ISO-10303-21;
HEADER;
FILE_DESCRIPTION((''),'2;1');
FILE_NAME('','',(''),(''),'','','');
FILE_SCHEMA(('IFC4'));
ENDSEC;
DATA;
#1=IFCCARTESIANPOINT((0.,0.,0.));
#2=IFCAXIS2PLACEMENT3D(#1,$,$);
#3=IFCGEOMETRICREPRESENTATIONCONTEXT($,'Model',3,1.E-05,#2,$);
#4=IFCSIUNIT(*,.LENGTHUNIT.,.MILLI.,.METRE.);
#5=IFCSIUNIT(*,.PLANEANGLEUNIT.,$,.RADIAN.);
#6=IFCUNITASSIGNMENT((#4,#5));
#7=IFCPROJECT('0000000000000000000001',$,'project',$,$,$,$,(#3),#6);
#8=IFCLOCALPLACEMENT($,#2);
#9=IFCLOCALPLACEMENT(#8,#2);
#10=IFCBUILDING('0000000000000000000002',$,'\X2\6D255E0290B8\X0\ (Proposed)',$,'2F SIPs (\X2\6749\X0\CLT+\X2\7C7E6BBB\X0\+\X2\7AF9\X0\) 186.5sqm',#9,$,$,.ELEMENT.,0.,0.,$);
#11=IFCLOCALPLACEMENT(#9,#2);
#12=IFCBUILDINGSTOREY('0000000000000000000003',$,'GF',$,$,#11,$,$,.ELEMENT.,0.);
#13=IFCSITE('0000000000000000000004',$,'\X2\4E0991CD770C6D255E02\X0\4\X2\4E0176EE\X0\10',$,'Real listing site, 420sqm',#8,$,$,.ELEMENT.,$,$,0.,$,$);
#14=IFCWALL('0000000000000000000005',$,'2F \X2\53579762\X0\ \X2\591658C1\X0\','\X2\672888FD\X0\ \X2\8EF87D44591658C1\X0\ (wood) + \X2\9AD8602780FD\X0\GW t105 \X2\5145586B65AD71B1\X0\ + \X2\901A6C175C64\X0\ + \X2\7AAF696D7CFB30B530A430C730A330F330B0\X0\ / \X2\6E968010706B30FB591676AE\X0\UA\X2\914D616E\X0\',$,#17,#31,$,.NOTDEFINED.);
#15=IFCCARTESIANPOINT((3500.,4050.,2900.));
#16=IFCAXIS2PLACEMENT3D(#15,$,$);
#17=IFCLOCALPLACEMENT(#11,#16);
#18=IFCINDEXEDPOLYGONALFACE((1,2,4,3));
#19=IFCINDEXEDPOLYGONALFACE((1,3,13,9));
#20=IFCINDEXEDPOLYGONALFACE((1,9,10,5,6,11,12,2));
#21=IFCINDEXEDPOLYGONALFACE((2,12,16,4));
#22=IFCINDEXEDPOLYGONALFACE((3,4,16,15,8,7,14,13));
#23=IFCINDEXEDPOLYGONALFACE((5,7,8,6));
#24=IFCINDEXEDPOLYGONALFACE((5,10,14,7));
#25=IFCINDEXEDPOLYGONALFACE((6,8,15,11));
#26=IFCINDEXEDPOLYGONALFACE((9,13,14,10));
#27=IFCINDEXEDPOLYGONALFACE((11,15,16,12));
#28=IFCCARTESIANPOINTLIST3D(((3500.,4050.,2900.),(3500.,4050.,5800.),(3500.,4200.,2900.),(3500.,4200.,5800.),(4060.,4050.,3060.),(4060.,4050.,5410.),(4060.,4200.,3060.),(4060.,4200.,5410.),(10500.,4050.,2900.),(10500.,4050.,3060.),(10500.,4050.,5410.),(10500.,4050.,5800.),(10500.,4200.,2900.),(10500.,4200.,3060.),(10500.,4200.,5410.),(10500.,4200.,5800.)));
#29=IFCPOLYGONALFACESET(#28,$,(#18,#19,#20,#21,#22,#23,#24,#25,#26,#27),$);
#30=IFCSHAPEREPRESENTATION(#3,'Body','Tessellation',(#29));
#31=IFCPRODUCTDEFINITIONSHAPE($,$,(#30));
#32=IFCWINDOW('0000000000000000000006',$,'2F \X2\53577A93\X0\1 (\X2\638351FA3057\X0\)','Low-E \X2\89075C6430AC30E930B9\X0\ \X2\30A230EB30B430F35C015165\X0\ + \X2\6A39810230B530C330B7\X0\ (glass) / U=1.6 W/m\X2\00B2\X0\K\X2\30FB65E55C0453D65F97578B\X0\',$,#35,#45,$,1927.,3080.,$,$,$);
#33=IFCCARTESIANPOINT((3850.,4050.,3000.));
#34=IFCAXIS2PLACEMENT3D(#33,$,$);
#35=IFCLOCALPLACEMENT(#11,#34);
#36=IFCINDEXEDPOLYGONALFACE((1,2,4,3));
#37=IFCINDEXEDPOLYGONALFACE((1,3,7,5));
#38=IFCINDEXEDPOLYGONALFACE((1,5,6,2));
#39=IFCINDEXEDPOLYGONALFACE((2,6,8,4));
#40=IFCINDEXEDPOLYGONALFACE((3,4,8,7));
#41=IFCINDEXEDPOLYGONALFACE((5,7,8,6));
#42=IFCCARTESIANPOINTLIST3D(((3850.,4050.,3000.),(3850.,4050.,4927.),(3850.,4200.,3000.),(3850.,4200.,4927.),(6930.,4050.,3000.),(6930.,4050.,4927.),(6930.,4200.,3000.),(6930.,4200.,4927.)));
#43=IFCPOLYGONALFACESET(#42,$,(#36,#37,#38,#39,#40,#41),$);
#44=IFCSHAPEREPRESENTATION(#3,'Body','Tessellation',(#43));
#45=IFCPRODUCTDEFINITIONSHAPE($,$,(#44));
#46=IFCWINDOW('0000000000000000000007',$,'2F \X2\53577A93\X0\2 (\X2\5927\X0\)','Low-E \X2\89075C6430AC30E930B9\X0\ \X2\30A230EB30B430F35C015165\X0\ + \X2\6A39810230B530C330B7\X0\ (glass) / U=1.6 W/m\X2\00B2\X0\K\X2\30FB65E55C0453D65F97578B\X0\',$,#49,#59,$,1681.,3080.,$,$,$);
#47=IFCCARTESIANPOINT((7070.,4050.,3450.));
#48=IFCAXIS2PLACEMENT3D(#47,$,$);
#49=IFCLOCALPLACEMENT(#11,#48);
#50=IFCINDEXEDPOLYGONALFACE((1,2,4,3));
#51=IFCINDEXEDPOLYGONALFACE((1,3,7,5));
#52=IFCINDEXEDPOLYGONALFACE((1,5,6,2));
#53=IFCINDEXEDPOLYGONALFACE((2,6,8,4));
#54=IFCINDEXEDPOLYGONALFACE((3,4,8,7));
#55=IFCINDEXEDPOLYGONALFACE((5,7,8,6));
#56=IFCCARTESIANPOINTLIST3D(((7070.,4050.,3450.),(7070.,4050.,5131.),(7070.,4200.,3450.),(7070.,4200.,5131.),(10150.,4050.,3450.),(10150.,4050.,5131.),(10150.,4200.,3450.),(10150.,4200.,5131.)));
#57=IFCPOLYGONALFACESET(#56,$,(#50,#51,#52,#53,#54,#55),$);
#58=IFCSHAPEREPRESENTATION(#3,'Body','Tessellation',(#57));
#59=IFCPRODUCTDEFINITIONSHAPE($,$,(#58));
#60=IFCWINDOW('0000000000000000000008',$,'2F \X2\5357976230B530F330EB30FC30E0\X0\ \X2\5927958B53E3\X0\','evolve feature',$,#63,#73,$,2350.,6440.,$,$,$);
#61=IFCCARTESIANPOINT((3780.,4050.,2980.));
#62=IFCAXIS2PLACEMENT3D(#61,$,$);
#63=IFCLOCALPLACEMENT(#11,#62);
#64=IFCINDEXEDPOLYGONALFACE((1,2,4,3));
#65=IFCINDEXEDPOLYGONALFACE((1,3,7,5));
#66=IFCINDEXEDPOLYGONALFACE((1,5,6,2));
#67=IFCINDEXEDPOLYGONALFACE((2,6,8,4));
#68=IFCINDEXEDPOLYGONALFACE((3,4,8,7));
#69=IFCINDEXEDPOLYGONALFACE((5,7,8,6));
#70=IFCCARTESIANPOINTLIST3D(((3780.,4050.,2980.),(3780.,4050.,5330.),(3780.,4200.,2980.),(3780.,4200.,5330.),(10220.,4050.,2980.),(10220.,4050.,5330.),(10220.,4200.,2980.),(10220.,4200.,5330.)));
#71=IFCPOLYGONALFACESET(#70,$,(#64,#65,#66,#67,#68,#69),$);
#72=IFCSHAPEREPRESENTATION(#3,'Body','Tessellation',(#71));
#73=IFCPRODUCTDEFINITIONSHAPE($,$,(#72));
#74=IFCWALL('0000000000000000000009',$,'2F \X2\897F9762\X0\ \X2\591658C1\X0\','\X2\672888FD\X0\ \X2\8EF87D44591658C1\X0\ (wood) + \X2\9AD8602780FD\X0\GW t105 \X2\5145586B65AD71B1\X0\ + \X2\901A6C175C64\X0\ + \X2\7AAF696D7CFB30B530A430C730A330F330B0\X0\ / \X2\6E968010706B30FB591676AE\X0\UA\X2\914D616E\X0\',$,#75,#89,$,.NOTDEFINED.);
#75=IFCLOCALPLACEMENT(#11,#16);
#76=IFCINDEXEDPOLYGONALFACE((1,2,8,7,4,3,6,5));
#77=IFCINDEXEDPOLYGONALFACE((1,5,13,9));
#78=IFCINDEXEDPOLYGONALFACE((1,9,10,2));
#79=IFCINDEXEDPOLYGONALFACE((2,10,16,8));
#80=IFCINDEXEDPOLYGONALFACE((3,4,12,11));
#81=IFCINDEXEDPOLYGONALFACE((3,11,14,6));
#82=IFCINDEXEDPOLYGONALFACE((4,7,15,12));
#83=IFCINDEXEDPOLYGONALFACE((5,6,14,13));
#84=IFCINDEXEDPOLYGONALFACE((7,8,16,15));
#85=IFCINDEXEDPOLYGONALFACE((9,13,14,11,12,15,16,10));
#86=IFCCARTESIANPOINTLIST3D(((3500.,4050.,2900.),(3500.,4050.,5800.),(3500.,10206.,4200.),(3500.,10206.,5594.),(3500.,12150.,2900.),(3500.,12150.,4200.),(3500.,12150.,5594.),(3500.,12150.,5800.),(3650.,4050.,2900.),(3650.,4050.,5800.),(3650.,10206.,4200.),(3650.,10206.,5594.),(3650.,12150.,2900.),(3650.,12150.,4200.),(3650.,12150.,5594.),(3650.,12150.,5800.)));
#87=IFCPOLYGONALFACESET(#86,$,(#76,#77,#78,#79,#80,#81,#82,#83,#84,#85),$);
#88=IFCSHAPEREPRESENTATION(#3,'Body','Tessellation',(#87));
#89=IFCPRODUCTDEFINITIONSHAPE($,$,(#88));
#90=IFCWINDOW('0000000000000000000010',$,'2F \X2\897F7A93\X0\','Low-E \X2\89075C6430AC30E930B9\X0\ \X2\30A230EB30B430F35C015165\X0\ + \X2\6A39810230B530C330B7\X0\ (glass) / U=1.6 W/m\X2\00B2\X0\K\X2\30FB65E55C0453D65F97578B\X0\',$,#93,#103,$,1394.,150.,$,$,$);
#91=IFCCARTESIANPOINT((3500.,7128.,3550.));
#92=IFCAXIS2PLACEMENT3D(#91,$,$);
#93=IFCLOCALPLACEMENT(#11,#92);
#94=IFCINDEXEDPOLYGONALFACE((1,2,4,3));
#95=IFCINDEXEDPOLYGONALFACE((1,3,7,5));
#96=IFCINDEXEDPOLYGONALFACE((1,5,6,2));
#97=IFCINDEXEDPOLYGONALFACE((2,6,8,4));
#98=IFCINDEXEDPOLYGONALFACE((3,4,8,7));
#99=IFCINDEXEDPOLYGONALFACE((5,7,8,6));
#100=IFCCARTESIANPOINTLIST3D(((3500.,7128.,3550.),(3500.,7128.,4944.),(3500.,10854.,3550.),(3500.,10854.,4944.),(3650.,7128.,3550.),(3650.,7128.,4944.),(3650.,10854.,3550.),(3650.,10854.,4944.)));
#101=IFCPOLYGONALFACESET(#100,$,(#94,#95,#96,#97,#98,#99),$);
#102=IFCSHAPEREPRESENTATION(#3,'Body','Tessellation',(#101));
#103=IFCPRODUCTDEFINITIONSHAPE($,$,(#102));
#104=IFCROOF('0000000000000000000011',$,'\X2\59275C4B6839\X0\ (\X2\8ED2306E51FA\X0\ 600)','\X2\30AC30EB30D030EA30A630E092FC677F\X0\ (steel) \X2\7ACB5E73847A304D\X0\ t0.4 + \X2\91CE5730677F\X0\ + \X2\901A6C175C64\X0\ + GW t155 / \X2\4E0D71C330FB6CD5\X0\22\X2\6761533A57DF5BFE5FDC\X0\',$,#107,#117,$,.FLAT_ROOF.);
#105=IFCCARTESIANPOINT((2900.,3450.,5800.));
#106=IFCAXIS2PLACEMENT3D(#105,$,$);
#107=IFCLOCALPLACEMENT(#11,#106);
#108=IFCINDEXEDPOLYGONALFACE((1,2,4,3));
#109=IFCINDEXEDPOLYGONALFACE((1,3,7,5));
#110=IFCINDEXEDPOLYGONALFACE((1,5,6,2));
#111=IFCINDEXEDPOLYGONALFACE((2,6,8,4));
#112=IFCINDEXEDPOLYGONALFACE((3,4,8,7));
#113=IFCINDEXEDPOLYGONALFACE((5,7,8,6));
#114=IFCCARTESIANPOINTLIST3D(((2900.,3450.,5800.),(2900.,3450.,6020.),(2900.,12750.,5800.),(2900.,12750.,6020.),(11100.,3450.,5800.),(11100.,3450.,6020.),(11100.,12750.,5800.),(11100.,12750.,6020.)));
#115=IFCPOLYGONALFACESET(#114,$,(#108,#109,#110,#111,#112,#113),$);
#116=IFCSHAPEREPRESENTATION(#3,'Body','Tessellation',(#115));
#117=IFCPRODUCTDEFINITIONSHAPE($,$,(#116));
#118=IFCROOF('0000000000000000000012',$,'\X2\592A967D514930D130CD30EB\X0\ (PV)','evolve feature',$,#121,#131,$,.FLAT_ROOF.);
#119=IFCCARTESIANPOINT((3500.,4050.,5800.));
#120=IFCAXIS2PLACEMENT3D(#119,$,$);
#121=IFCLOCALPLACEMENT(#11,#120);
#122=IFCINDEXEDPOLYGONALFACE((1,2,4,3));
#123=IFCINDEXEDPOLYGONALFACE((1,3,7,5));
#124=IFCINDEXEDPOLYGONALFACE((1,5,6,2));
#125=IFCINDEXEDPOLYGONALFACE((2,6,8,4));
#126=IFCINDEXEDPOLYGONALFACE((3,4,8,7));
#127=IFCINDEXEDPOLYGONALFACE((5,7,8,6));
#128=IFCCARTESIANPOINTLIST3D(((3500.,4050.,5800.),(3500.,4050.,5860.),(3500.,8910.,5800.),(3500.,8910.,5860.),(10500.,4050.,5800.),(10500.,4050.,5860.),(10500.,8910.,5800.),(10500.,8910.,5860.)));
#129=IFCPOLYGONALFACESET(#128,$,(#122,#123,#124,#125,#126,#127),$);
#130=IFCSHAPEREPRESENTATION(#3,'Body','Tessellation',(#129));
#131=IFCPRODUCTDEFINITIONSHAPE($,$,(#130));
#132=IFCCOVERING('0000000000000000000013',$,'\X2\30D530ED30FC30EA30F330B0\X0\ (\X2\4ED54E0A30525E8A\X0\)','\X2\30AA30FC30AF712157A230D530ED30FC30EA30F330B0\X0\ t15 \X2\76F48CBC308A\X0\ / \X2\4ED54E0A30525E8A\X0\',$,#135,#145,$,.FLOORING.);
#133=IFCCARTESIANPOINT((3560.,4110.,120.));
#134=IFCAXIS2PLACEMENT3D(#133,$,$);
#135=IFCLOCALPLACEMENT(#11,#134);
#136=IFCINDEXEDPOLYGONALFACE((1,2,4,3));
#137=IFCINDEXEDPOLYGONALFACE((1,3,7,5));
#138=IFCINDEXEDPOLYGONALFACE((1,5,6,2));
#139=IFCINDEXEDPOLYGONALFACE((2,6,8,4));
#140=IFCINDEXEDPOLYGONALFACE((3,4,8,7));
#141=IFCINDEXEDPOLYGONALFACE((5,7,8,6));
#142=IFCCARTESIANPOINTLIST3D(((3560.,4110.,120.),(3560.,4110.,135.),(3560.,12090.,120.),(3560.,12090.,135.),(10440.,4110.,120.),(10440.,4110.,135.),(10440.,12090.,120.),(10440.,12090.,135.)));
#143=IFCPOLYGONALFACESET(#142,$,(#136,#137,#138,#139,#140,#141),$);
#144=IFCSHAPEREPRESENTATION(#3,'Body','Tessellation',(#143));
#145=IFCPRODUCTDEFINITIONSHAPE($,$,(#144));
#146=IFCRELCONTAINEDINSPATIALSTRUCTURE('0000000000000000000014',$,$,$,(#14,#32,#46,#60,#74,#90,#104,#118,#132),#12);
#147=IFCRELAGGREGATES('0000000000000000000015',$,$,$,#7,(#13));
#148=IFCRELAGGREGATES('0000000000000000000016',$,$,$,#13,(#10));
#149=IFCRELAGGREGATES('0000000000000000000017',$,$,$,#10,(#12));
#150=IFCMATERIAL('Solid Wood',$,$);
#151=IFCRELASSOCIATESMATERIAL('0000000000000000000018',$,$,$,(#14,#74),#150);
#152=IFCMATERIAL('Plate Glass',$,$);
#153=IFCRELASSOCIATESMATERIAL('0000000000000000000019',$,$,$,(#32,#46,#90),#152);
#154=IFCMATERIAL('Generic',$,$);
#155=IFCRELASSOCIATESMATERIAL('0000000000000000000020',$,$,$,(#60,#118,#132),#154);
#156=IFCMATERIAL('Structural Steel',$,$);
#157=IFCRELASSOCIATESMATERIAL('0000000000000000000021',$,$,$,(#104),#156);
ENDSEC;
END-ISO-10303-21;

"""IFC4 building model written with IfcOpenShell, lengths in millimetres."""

from ifc_helpers import new_model, si_unit, frame, frame_2d, origin, place, context, project, spatial, rectangle, extrude, material, element, fill, save


model = new_model("IFC4")

# Units and contexts
model_context = context("Model", 3, precision=1e-05, world=origin())
ifc_project = project(units=[si_unit("LENGTHUNIT", "METRE", prefix="MILLI"), si_unit("PLANEANGLEUNIT", "RADIAN")], contexts=[model_context])

# Site, building, storey
site_placement = place(None, origin())
site = spatial("IfcSite", under=ifc_project, at=site_placement, Name="三重県津市4丁目10", ObjectType="Real listing site, 420sqm", CompositionType="ELEMENT", RefElevation=0.0)
building_placement = place(site_placement, origin())
building = spatial("IfcBuilding", under=site, at=building_placement, Name="津市邸 (Proposed)", ObjectType="2F SIPs (杉CLT+籾殻+竹) 186.5sqm", CompositionType="ELEMENT", ElevationOfRefHeight=0.0, ElevationOfTerrain=0.0)
storey_placement = place(building_placement, origin())
storey = spatial("IfcBuildingStorey", under=building, at=storey_placement, Name="GF", CompositionType="ELEMENT", Elevation=0.0)

# Shared definitions
ifc_material_1 = material(Name="Solid Wood")
ifc_material_2 = material(Name="Generic")

# Shared definitions
ifc_material_3 = material(Name="Plate Glass")

# Wall, openings, windows
wall_1_placement = place(storey_placement, frame((3500.0, 4050.0, 2900.0)))
wall_1 = element("IfcWall", 1, at=wall_1_placement, inside=storey, material=ifc_material_1, Name="2F 南面 外壁", Description="木製 軸組外壁 (wood) + 高性能GW t105 充填断熱 + 通気層 + 窯業系サイディング / 準耐火・外皮UA配慮", PredefinedType="NOTDEFINED", context=model_context, shape_type="SweptSolid", body=[
    extrude(rectangle(XDim=7000.0, YDim=150.0, at=frame_2d((3500.0, 75.0))), frame((3500.0, 4050.0, 2900.0)), (0.0, 0.0, 1.0), 2900.0),
])
opening_1_placement = place(storey_placement, frame((3850.0, 4050.0, 3000.0)))
opening_1 = element("IfcOpeningElement", 2, at=opening_1_placement, cuts=wall_1, PredefinedType="NOTDEFINED", context=model_context, shape_type="SweptSolid", body=[
    extrude(rectangle(XDim=3080.0, YDim=150.0, at=frame_2d((1540.0, 75.0))), frame((3850.0, 4050.0, 3000.0)), (0.0, 0.0, 1.0), 1927.0),
])
opening_2_placement = place(storey_placement, frame((7070.0, 4050.0, 3450.0)))
opening_2 = element("IfcOpeningElement", 3, at=opening_2_placement, cuts=wall_1, PredefinedType="NOTDEFINED", context=model_context, shape_type="SweptSolid", body=[
    extrude(rectangle(XDim=3080.0, YDim=150.0, at=frame_2d((1540.0, 75.0))), frame((7070.0, 4050.0, 3450.0)), (0.0, 0.0, 1.0), 1681.0),
])
opening_3_placement = place(storey_placement, frame((3780.0, 4050.0, 2980.0)))
opening_3 = element("IfcOpeningElement", 4, at=opening_3_placement, cuts=wall_1, PredefinedType="NOTDEFINED", context=model_context, shape_type="SweptSolid", body=[
    extrude(rectangle(XDim=6440.0, YDim=150.0, at=frame_2d((3220.0, 75.0))), frame((3780.0, 4050.0, 2980.0)), (0.0, 0.0, 1.0), 2350.0),
])
window_1_placement = place(storey_placement, frame((3850.0, 4050.0, 3000.0)))
window_1 = element("IfcWindow", 5, at=window_1_placement, inside=storey, material=ifc_material_3, Name="2F 南窓1 (掃出し)", Description="Low-E 複層ガラス アルゴン封入 + 樹脂サッシ (glass) / U=1.6 W/m²K・日射取得型", OverallHeight=1927.0, OverallWidth=3080.0, context=model_context, shape_type="SweptSolid", body=[
    extrude(rectangle(XDim=3080.0, YDim=150.0, at=frame_2d((1540.0, 75.0))), frame((3850.0, 4050.0, 3000.0)), (0.0, 0.0, 1.0), 1927.0),
])
fill(opening_1, window_1)
window_2_placement = place(storey_placement, frame((7070.0, 4050.0, 3450.0)))
window_2 = element("IfcWindow", 6, at=window_2_placement, inside=storey, material=ifc_material_3, Name="2F 南窓2 (大)", Description="Low-E 複層ガラス アルゴン封入 + 樹脂サッシ (glass) / U=1.6 W/m²K・日射取得型", OverallHeight=1681.0, OverallWidth=3080.0, context=model_context, shape_type="SweptSolid", body=[
    extrude(rectangle(XDim=3080.0, YDim=150.0, at=frame_2d((1540.0, 75.0))), frame((7070.0, 4050.0, 3450.0)), (0.0, 0.0, 1.0), 1681.0),
])
fill(opening_2, window_2)
window_3_placement = place(storey_placement, frame((3780.0, 4050.0, 2980.0)))
window_3 = element("IfcWindow", 7, at=window_3_placement, inside=storey, material=ifc_material_2, Name="2F 南面サンルーム 大開口", Description="evolve feature", OverallHeight=2350.0, OverallWidth=6440.0, context=model_context, shape_type="SweptSolid", body=[
    extrude(rectangle(XDim=6440.0, YDim=150.0, at=frame_2d((3220.0, 75.0))), frame((3780.0, 4050.0, 2980.0)), (0.0, 0.0, 1.0), 2350.0),
])
fill(opening_3, window_3)

# Wall, opening, window
wall_2_placement = place(storey_placement, frame((3500.0, 4050.0, 2900.0)))
wall_2 = element("IfcWall", 8, at=wall_2_placement, inside=storey, material=ifc_material_1, Name="2F 西面 外壁", Description="木製 軸組外壁 (wood) + 高性能GW t105 充填断熱 + 通気層 + 窯業系サイディング / 準耐火・外皮UA配慮", PredefinedType="NOTDEFINED", context=model_context, shape_type="SweptSolid", body=[
    extrude(rectangle(XDim=150.0, YDim=8100.0, at=frame_2d((75.0, 4050.0))), frame((3500.0, 4050.0, 2900.0)), (0.0, 0.0, 1.0), 2900.0),
])
opening_4_placement = place(storey_placement, frame((3500.0, 7128.0, 3550.0)))
opening_4 = element("IfcOpeningElement", 9, at=opening_4_placement, cuts=wall_2, PredefinedType="NOTDEFINED", context=model_context, shape_type="SweptSolid", body=[
    extrude(rectangle(XDim=150.0, YDim=3726.0, at=frame_2d((75.0, 1863.0))), frame((3500.0, 7128.0, 3550.0)), (0.0, 0.0, 1.0), 1394.0),
])
window_4_placement = place(storey_placement, frame((3500.0, 7128.0, 3550.0)))
window_4 = element("IfcWindow", 10, at=window_4_placement, inside=storey, material=ifc_material_3, Name="2F 西窓", Description="Low-E 複層ガラス アルゴン封入 + 樹脂サッシ (glass) / U=1.6 W/m²K・日射取得型", OverallHeight=1394.0, OverallWidth=150.0, context=model_context, shape_type="SweptSolid", body=[
    extrude(rectangle(XDim=150.0, YDim=3726.0, at=frame_2d((75.0, 1863.0))), frame((3500.0, 7128.0, 3550.0)), (0.0, 0.0, 1.0), 1394.0),
])
fill(opening_4, window_4)

# Roofs
ifc_material_4 = material(Name="Structural Steel")
roof_1_placement = place(storey_placement, frame((2900.0, 3450.0, 5800.0)))
element("IfcRoof", 11, at=roof_1_placement, inside=storey, material=ifc_material_4, Name="大屋根 (軒の出 600)", Description="ガルバリウム鋼板 (steel) 立平葺き t0.4 + 野地板 + 通気層 + GW t155 / 不燃・法22条区域対応", PredefinedType="FLAT_ROOF", context=model_context, shape_type="SweptSolid", body=[
    extrude(rectangle(XDim=8200.0, YDim=9300.0, at=frame_2d((4100.0, 4650.0))), frame((2900.0, 3450.0, 5800.0)), (0.0, 0.0, 1.0), 220.0),
])
roof_2_placement = place(storey_placement, frame((3500.0, 4050.0, 5800.0)))
element("IfcRoof", 12, at=roof_2_placement, inside=storey, material=ifc_material_2, Name="太陽光パネル (PV)", Description="evolve feature", PredefinedType="FLAT_ROOF", context=model_context, shape_type="SweptSolid", body=[
    extrude(rectangle(XDim=7000.0, YDim=4860.0, at=frame_2d((3500.0, 2430.0))), frame((3500.0, 4050.0, 5800.0)), (0.0, 0.0, 1.0), 60.0),
])

# Covering
covering_placement = place(storey_placement, frame((3560.0, 4110.0, 120.0)))
element("IfcCovering", 13, at=covering_placement, inside=storey, material=ifc_material_2, Name="フローリング (仕上げ床)", Description="オーク無垢フローリング t15 直貼り / 仕上げ床", PredefinedType="FLOORING", context=model_context, shape_type="SweptSolid", body=[
    extrude(rectangle(XDim=6880.0, YDim=7980.0, at=frame_2d((3440.0, 3990.0))), frame((3560.0, 4110.0, 120.0)), (0.0, 0.0, 1.0), 15.0),
])

save(model, "model.ifc")
